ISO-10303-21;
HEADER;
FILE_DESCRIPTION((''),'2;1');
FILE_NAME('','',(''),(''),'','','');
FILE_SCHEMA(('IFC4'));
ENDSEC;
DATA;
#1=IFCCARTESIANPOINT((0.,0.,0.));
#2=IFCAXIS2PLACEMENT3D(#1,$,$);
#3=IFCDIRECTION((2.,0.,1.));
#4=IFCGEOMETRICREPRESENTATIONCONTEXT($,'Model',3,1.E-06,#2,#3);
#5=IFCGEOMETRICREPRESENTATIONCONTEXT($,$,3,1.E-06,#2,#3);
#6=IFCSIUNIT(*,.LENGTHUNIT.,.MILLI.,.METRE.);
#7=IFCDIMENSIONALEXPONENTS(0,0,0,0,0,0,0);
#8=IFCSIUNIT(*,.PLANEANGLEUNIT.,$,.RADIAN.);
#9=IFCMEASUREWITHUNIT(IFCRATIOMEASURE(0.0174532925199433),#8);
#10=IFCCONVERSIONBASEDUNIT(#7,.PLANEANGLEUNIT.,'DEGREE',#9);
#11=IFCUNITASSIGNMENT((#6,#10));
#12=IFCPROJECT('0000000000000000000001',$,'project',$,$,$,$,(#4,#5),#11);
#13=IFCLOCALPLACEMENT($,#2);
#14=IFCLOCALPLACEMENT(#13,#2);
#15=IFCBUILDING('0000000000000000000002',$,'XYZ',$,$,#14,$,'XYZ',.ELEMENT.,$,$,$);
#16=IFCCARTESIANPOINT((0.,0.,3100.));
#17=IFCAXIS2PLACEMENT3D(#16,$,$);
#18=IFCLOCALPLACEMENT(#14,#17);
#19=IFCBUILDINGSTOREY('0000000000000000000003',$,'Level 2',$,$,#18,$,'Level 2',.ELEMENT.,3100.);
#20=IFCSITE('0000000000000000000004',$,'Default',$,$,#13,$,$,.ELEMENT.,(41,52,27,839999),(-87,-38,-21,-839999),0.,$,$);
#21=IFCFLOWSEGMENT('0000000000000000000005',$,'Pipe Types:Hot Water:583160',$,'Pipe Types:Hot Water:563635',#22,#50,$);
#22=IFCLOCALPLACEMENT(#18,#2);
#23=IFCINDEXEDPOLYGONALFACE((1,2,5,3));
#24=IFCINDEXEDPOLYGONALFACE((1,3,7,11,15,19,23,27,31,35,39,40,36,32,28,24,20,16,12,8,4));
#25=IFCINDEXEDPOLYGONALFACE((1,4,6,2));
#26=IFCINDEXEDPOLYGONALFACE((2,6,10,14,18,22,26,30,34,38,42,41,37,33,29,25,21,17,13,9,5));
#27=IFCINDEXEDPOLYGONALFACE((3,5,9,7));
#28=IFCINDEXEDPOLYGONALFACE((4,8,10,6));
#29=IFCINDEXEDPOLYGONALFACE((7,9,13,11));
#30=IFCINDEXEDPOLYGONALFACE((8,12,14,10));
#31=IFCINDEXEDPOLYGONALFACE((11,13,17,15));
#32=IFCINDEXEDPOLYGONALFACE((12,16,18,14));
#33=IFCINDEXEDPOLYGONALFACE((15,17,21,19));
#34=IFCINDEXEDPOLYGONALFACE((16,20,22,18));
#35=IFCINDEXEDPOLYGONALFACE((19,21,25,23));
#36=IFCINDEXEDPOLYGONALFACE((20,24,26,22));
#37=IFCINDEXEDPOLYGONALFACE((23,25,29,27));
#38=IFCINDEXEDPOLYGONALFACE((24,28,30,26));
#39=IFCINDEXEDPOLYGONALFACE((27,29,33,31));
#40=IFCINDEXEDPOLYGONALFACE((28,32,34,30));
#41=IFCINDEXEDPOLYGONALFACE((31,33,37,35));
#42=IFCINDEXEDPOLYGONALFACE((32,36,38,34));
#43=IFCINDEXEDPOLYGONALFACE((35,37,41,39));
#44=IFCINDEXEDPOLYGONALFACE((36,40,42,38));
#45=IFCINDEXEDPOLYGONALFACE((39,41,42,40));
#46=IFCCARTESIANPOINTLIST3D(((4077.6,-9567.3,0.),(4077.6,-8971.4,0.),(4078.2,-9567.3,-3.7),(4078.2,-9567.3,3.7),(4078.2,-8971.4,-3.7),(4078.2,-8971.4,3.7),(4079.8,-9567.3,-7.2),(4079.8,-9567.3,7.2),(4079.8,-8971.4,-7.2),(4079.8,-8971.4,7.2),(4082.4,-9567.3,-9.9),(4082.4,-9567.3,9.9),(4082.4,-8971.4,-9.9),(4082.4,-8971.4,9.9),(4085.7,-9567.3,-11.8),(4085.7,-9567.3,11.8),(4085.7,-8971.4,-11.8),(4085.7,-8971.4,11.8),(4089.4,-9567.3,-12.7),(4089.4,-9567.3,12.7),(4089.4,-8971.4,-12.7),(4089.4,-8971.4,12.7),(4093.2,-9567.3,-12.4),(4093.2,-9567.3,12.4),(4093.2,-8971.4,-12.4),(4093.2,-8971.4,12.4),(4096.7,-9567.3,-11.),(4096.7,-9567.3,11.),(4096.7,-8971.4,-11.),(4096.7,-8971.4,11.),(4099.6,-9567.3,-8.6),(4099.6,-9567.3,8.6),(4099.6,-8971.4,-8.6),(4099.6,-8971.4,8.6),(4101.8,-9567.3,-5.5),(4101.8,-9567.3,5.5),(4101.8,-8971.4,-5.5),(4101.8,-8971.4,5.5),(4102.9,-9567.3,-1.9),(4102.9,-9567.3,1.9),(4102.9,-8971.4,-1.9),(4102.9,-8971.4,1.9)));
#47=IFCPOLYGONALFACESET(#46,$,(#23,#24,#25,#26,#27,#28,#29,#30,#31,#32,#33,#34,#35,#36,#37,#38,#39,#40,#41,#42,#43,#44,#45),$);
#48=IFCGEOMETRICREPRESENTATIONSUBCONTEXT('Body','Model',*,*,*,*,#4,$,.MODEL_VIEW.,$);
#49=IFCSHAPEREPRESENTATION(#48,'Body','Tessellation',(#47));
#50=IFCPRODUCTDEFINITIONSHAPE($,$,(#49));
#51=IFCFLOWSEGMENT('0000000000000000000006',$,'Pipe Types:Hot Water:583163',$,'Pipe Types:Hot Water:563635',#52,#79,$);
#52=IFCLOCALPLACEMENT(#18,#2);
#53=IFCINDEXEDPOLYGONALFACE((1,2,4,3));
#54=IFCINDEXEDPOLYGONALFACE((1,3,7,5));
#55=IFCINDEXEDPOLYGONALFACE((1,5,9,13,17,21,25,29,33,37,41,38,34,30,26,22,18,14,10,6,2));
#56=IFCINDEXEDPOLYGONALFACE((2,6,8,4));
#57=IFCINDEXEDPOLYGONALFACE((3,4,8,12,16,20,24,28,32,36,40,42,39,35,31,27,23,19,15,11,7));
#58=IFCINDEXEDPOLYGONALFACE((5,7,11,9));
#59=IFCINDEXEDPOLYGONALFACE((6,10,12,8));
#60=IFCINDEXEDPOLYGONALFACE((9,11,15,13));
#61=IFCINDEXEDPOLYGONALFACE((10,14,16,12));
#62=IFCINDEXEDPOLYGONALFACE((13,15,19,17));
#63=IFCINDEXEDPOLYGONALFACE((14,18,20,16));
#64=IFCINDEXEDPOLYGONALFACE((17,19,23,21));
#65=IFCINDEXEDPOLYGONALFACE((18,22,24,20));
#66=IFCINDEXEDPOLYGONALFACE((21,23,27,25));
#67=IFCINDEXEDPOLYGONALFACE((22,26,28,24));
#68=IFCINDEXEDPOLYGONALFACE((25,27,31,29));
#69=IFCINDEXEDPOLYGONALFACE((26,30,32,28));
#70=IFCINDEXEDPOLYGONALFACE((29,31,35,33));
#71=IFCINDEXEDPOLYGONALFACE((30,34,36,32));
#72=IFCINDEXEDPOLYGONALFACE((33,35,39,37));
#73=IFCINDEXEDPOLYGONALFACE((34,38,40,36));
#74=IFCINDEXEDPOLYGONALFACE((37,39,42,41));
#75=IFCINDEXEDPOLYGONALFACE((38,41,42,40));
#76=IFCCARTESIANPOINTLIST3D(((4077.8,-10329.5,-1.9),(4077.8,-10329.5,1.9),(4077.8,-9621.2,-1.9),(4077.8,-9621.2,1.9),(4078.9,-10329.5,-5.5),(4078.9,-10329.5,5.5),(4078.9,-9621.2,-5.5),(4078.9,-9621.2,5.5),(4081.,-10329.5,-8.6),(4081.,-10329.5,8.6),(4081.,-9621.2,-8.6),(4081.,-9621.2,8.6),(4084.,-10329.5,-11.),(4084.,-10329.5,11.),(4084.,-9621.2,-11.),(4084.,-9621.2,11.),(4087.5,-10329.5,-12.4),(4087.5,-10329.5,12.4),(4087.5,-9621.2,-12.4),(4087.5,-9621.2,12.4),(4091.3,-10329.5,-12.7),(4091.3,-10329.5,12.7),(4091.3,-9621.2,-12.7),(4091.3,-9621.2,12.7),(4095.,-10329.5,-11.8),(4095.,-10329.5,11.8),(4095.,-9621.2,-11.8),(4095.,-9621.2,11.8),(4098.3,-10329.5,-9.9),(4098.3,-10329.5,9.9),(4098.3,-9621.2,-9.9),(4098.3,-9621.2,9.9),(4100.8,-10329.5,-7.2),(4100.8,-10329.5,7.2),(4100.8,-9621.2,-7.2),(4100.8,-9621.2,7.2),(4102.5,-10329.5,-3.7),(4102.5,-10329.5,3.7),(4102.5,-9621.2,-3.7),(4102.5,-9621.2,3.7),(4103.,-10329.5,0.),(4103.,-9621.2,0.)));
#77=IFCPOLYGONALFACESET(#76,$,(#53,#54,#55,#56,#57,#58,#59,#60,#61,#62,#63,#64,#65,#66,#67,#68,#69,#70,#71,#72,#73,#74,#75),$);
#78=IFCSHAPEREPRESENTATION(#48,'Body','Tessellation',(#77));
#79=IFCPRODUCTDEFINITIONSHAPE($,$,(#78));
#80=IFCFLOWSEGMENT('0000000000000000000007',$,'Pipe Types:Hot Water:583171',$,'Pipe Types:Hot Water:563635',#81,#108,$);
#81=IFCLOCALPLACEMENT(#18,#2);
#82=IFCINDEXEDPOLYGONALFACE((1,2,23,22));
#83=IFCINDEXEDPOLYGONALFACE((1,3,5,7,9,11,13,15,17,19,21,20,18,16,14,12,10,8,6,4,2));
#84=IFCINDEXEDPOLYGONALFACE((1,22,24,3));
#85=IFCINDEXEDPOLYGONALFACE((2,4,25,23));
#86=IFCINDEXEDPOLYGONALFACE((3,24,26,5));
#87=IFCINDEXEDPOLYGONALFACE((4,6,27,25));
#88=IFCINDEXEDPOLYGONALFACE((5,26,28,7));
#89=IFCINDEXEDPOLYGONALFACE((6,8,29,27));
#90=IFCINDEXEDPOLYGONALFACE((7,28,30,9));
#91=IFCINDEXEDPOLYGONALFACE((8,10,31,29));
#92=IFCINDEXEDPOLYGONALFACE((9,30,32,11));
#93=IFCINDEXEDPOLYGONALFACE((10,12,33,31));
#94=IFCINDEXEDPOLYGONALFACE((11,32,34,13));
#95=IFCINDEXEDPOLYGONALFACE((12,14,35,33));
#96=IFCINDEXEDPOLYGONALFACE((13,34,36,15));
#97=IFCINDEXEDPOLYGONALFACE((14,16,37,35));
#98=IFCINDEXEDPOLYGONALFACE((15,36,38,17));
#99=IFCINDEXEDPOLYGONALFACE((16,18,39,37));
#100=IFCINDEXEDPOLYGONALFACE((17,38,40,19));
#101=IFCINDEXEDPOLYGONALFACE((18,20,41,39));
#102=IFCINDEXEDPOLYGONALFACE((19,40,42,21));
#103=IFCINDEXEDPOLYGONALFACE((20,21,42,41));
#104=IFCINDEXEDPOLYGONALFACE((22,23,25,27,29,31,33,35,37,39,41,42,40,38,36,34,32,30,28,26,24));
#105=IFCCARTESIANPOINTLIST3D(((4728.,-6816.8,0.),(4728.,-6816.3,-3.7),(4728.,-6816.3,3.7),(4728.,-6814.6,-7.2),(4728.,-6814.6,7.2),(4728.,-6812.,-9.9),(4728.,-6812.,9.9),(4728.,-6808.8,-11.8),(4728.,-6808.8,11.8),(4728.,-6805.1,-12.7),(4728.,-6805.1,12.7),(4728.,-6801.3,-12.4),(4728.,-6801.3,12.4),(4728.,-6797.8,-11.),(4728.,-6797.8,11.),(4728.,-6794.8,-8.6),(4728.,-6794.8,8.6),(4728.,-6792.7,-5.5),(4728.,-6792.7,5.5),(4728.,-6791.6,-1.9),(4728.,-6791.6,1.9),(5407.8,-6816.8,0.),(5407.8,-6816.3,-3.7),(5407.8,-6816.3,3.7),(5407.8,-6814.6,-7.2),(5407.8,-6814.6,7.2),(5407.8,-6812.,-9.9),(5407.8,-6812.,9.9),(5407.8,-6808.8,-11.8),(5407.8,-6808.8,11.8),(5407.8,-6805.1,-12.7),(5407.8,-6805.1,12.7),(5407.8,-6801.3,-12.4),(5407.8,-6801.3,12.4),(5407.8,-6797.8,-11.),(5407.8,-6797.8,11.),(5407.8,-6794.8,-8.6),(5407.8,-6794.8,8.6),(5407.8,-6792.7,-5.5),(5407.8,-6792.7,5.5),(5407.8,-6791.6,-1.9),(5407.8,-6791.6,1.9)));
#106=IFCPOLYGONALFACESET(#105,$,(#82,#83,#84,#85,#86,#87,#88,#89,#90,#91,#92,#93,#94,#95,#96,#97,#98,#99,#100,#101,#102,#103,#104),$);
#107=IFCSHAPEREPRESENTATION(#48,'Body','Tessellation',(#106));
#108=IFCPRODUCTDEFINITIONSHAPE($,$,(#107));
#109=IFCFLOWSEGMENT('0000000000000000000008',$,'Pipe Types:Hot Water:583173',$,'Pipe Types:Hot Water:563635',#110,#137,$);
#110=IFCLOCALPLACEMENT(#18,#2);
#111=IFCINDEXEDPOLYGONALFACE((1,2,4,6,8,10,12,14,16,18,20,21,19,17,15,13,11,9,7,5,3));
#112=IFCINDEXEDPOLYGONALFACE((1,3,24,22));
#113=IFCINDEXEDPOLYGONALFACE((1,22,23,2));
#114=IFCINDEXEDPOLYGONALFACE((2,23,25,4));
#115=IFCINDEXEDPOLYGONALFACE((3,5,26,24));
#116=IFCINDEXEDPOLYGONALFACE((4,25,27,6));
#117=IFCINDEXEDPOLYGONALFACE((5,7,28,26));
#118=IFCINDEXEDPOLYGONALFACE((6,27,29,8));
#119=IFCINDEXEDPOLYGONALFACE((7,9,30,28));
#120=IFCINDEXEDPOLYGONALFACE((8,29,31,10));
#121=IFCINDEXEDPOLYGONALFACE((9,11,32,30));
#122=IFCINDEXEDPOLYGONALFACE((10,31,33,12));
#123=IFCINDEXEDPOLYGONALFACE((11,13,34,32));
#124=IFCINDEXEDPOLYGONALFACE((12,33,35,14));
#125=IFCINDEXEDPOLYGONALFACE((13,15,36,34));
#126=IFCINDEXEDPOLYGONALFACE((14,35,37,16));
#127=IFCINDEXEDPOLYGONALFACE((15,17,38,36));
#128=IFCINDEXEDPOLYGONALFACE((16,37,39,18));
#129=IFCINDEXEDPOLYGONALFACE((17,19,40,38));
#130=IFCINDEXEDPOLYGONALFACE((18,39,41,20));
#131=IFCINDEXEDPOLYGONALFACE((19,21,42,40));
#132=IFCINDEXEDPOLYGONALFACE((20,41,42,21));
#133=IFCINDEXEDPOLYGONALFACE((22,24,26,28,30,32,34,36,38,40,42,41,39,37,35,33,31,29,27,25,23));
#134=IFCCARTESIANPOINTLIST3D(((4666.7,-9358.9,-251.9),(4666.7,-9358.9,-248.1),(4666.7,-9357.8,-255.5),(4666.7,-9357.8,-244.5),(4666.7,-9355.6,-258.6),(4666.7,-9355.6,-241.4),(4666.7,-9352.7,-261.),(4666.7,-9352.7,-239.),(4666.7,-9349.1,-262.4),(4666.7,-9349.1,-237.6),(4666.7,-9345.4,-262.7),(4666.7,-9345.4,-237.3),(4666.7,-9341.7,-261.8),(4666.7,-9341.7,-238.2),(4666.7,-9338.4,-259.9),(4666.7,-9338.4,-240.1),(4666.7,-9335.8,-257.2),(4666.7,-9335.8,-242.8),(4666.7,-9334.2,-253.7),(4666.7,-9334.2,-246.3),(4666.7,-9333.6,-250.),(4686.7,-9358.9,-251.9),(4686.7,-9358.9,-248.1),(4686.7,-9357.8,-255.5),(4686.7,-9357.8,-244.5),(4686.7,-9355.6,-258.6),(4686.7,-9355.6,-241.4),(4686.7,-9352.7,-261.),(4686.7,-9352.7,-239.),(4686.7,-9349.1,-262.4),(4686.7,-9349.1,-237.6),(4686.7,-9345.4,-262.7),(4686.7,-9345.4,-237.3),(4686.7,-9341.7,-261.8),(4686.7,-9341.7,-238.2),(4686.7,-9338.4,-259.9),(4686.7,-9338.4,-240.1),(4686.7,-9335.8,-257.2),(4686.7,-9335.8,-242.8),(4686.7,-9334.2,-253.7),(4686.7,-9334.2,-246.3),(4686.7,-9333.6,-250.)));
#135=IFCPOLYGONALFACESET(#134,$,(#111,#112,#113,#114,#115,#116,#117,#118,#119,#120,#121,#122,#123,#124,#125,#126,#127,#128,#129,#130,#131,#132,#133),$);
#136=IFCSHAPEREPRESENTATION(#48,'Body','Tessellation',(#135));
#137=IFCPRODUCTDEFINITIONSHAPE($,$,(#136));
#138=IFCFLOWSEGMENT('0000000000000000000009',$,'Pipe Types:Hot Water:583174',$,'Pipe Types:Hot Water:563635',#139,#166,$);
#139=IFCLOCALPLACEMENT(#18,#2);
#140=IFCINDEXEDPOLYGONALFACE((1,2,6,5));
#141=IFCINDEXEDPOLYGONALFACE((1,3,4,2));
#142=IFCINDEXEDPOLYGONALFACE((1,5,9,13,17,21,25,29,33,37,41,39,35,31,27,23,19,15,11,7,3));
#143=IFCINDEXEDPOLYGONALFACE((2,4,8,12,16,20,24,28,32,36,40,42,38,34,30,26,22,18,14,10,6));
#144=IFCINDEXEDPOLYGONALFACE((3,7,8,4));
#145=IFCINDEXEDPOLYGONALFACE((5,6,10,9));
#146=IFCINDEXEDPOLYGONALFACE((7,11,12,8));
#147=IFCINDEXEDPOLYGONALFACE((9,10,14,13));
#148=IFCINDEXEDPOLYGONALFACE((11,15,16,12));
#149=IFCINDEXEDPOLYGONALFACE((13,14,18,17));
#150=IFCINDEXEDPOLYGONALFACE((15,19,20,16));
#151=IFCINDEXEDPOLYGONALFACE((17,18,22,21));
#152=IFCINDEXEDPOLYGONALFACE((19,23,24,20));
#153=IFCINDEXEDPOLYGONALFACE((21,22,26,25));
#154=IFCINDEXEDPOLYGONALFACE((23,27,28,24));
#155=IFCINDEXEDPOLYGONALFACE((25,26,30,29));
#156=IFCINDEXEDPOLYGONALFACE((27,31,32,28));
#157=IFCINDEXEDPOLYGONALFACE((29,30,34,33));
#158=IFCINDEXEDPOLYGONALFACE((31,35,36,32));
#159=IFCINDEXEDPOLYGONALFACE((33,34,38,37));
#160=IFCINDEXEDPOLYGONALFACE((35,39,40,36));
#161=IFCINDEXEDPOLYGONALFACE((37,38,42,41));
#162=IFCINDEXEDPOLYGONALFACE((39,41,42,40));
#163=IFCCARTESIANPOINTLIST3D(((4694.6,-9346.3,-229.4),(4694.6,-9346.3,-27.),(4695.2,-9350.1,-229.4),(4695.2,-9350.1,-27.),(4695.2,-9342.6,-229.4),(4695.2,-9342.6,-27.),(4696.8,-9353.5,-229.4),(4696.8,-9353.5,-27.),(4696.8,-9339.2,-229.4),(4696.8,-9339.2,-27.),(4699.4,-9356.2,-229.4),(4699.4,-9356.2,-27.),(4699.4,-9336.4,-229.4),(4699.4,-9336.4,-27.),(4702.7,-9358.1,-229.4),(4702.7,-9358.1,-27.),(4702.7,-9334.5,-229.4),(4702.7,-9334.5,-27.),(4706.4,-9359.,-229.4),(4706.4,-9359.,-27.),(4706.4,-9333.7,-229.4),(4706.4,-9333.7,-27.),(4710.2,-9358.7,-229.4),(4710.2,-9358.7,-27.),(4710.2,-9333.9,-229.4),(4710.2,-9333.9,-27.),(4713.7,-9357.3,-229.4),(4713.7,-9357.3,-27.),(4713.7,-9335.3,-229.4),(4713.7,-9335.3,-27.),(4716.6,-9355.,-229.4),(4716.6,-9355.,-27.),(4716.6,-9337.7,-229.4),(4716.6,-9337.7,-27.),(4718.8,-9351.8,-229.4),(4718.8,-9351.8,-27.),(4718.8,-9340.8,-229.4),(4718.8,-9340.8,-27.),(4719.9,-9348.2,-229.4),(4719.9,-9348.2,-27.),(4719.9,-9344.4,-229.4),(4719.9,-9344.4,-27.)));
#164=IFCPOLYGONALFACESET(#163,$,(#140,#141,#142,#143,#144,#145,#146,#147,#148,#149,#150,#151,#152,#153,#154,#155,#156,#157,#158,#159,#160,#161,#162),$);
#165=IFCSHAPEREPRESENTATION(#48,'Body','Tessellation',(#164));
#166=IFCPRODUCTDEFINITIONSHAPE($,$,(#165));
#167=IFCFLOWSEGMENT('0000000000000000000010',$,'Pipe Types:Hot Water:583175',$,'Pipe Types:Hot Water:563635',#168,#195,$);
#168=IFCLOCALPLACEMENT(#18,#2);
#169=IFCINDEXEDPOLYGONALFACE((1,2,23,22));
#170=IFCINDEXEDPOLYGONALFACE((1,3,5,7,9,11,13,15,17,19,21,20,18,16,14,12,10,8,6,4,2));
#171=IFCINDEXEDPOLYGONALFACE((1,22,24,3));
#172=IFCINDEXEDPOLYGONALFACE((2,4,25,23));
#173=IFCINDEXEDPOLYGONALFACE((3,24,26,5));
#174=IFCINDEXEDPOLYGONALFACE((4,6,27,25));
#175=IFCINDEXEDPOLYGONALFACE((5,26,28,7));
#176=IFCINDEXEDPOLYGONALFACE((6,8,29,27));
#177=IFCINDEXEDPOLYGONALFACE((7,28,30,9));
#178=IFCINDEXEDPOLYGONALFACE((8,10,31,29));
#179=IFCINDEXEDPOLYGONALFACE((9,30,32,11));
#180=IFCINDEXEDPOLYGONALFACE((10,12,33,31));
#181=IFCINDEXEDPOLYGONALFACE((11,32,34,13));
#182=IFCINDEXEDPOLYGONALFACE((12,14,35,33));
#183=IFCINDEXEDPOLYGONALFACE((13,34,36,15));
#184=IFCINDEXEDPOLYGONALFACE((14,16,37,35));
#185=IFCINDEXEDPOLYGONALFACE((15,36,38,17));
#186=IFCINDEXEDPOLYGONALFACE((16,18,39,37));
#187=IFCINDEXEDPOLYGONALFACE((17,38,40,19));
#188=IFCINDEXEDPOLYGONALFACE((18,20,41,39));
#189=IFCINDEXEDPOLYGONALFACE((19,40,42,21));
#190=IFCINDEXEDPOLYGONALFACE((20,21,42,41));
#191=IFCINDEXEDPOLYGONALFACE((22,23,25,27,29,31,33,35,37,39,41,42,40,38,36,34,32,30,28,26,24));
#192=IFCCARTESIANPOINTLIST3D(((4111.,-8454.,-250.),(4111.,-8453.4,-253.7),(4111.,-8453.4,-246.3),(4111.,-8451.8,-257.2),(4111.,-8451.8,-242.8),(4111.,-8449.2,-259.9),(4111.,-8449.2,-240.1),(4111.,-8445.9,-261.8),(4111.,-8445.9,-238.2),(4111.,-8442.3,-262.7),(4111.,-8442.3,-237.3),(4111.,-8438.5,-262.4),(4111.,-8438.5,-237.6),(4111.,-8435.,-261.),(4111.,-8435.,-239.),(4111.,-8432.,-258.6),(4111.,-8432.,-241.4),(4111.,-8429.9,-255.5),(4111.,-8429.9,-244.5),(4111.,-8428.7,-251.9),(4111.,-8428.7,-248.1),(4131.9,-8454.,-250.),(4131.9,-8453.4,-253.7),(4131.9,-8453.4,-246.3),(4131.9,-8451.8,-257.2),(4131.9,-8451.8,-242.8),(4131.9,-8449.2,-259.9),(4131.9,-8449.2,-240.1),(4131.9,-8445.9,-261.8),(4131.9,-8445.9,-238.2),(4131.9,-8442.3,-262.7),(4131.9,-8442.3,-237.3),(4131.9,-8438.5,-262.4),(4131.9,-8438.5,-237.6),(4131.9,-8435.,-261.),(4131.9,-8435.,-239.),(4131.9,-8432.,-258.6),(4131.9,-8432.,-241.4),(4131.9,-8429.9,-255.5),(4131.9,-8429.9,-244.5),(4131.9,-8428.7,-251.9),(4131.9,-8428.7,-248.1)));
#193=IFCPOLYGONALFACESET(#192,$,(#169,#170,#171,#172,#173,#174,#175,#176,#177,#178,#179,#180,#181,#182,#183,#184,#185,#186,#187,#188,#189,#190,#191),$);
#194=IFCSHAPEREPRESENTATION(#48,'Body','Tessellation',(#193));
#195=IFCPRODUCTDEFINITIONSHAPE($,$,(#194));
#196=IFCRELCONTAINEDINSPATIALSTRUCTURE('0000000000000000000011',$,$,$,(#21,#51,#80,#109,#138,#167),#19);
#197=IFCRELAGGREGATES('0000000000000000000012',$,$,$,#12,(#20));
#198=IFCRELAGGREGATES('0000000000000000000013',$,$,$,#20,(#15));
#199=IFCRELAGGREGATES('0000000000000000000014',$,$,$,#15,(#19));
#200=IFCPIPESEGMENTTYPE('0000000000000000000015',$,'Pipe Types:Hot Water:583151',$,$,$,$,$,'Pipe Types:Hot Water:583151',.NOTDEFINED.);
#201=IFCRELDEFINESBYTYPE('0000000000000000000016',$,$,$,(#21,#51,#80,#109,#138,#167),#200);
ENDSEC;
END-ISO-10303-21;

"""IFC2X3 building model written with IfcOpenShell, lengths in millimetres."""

from ifc_helpers import new_model, entity, si_unit, converted_unit, direction, frame, frame_2d, origin, origin_2d_with_axis, place, context, subcontext, project, spatial, circle, extrude, type_object, element, save


model = new_model("IFC2X3")

# Units and contexts
model_context = context("Model", 3, precision=1e-06, world=origin(), true_north=direction((2.0, 0.0, 1.0)))
context_of_model = context(None, 3, precision=1e-06, world=origin(), true_north=direction((2.0, 0.0, 1.0)))
body_context = subcontext(model_context, "Body", "Model", "MODEL_VIEW")
ifc_project = project(units=[si_unit("LENGTHUNIT", "METRE", prefix="MILLI"), converted_unit("PLANEANGLEUNIT", "DEGREE", entity("IfcRatioMeasure", 0.0174532925199433), si_unit("PLANEANGLEUNIT", "RADIAN"), dimensions=[0, 0, 0, 0, 0, 0, 0])], contexts=[model_context, context_of_model])

# Site, building, storey
site_placement = place(None, origin())
site = spatial("IfcSite", under=ifc_project, at=site_placement, Name="Default", CompositionType="ELEMENT", RefLatitude=(41, 52, 27, 839999), RefLongitude=(-87, -38, -21, -839999), RefElevation=0.0)
building_placement = place(site_placement, origin())
building = spatial("IfcBuilding", under=site, at=building_placement, Name="XYZ", LongName="XYZ", CompositionType="ELEMENT")
storey_placement = place(building_placement, frame((0.0, 0.0, 3100.0)))
storey = spatial("IfcBuildingStorey", under=building, at=storey_placement, Name="Level 2", LongName="Level 2", CompositionType="ELEMENT", Elevation=3100.0)

# Flow segments
pipe_segment_type_1 = type_object("IfcPipeSegmentType", Name="Pipe Types:Hot Water:583151", ElementType="Pipe Types:Hot Water:583151", PredefinedType="NOTDEFINED")
flow_segment_1_placement = place(storey_placement, origin())
element("IfcFlowSegment", 1, at=flow_segment_1_placement, inside=storey, type_object=pipe_segment_type_1, Name="Pipe Types:Hot Water:583160", ObjectType="Pipe Types:Hot Water:563635", context=body_context, shape_type="SweptSolid", body=[
    extrude(circle(Radius=12.7, at=origin_2d_with_axis()), frame((4090.3, -9567.3, 0.0), z_axis=(0.0, 1.0, 0.0), x_axis=(-1.0, 0.0, 0.0)), (0.0, 0.0, 1.0), 595.9),
])
flow_segment_2_placement = place(storey_placement, origin())
element("IfcFlowSegment", 2, at=flow_segment_2_placement, inside=storey, type_object=pipe_segment_type_1, Name="Pipe Types:Hot Water:583163", ObjectType="Pipe Types:Hot Water:563635", context=body_context, shape_type="SweptSolid", body=[
    extrude(circle(Radius=12.7, at=frame_2d((0.0, 0.0), x_axis=(1.0, 0.0))), frame((4090.3, -10329.5, 0.0), z_axis=(0.0, 1.0, 0.0), x_axis=(1.0, 0.0, 0.0)), (0.0, 0.0, 1.0), 708.2),
])
flow_segment_3_placement = place(storey_placement, origin())
element("IfcFlowSegment", 3, at=flow_segment_3_placement, inside=storey, type_object=pipe_segment_type_1, Name="Pipe Types:Hot Water:583171", ObjectType="Pipe Types:Hot Water:563635", context=body_context, shape_type="SweptSolid", body=[
    extrude(circle(Radius=12.7, at=frame_2d((0.0, 0.0), x_axis=(1.0, 0.0))), frame((4728.0, -6804.1, 0.0), z_axis=(1.0, 0.0, 0.0), x_axis=(0.0, -1.0, 0.0)), (0.0, 0.0, 1.0), 679.9),
])
flow_segment_4_placement = place(storey_placement, origin())
element("IfcFlowSegment", 4, at=flow_segment_4_placement, inside=storey, type_object=pipe_segment_type_1, Name="Pipe Types:Hot Water:583173", ObjectType="Pipe Types:Hot Water:563635", context=body_context, shape_type="SweptSolid", body=[
    extrude(circle(Radius=12.7, at=frame_2d((0.0, 0.0), x_axis=(1.0, 0.0))), frame((4666.7, -9346.3, -250.0), z_axis=(1.0, 0.0, 0.0), x_axis=(0.0, 1.0, 0.0)), (0.0, 0.0, 1.0), 20.0),
])
flow_segment_5_placement = place(storey_placement, origin())
element("IfcFlowSegment", 5, at=flow_segment_5_placement, inside=storey, type_object=pipe_segment_type_1, Name="Pipe Types:Hot Water:583174", ObjectType="Pipe Types:Hot Water:563635", context=body_context, shape_type="SweptSolid", body=[
    extrude(circle(Radius=12.7, at=origin_2d_with_axis()), frame((4707.3, -9346.3, -229.4), z_axis=(0.0, 0.0, 1.0), x_axis=(-1.0, 0.0, 0.0)), (0.0, 0.0, 1.0), 202.4),
])
flow_segment_6_placement = place(storey_placement, origin())
element("IfcFlowSegment", 6, at=flow_segment_6_placement, inside=storey, type_object=pipe_segment_type_1, Name="Pipe Types:Hot Water:583175", ObjectType="Pipe Types:Hot Water:563635", context=body_context, shape_type="SweptSolid", body=[
    extrude(circle(Radius=12.7, at=frame_2d((0.0, 0.0), x_axis=(1.0, 0.0))), frame((4111.0, -8441.3, -250.0), z_axis=(1.0, 0.0, 0.0), x_axis=(0.0, -1.0, 0.0)), (0.0, 0.0, 1.0), 21.0),
])

save(model, "model.ifc")
